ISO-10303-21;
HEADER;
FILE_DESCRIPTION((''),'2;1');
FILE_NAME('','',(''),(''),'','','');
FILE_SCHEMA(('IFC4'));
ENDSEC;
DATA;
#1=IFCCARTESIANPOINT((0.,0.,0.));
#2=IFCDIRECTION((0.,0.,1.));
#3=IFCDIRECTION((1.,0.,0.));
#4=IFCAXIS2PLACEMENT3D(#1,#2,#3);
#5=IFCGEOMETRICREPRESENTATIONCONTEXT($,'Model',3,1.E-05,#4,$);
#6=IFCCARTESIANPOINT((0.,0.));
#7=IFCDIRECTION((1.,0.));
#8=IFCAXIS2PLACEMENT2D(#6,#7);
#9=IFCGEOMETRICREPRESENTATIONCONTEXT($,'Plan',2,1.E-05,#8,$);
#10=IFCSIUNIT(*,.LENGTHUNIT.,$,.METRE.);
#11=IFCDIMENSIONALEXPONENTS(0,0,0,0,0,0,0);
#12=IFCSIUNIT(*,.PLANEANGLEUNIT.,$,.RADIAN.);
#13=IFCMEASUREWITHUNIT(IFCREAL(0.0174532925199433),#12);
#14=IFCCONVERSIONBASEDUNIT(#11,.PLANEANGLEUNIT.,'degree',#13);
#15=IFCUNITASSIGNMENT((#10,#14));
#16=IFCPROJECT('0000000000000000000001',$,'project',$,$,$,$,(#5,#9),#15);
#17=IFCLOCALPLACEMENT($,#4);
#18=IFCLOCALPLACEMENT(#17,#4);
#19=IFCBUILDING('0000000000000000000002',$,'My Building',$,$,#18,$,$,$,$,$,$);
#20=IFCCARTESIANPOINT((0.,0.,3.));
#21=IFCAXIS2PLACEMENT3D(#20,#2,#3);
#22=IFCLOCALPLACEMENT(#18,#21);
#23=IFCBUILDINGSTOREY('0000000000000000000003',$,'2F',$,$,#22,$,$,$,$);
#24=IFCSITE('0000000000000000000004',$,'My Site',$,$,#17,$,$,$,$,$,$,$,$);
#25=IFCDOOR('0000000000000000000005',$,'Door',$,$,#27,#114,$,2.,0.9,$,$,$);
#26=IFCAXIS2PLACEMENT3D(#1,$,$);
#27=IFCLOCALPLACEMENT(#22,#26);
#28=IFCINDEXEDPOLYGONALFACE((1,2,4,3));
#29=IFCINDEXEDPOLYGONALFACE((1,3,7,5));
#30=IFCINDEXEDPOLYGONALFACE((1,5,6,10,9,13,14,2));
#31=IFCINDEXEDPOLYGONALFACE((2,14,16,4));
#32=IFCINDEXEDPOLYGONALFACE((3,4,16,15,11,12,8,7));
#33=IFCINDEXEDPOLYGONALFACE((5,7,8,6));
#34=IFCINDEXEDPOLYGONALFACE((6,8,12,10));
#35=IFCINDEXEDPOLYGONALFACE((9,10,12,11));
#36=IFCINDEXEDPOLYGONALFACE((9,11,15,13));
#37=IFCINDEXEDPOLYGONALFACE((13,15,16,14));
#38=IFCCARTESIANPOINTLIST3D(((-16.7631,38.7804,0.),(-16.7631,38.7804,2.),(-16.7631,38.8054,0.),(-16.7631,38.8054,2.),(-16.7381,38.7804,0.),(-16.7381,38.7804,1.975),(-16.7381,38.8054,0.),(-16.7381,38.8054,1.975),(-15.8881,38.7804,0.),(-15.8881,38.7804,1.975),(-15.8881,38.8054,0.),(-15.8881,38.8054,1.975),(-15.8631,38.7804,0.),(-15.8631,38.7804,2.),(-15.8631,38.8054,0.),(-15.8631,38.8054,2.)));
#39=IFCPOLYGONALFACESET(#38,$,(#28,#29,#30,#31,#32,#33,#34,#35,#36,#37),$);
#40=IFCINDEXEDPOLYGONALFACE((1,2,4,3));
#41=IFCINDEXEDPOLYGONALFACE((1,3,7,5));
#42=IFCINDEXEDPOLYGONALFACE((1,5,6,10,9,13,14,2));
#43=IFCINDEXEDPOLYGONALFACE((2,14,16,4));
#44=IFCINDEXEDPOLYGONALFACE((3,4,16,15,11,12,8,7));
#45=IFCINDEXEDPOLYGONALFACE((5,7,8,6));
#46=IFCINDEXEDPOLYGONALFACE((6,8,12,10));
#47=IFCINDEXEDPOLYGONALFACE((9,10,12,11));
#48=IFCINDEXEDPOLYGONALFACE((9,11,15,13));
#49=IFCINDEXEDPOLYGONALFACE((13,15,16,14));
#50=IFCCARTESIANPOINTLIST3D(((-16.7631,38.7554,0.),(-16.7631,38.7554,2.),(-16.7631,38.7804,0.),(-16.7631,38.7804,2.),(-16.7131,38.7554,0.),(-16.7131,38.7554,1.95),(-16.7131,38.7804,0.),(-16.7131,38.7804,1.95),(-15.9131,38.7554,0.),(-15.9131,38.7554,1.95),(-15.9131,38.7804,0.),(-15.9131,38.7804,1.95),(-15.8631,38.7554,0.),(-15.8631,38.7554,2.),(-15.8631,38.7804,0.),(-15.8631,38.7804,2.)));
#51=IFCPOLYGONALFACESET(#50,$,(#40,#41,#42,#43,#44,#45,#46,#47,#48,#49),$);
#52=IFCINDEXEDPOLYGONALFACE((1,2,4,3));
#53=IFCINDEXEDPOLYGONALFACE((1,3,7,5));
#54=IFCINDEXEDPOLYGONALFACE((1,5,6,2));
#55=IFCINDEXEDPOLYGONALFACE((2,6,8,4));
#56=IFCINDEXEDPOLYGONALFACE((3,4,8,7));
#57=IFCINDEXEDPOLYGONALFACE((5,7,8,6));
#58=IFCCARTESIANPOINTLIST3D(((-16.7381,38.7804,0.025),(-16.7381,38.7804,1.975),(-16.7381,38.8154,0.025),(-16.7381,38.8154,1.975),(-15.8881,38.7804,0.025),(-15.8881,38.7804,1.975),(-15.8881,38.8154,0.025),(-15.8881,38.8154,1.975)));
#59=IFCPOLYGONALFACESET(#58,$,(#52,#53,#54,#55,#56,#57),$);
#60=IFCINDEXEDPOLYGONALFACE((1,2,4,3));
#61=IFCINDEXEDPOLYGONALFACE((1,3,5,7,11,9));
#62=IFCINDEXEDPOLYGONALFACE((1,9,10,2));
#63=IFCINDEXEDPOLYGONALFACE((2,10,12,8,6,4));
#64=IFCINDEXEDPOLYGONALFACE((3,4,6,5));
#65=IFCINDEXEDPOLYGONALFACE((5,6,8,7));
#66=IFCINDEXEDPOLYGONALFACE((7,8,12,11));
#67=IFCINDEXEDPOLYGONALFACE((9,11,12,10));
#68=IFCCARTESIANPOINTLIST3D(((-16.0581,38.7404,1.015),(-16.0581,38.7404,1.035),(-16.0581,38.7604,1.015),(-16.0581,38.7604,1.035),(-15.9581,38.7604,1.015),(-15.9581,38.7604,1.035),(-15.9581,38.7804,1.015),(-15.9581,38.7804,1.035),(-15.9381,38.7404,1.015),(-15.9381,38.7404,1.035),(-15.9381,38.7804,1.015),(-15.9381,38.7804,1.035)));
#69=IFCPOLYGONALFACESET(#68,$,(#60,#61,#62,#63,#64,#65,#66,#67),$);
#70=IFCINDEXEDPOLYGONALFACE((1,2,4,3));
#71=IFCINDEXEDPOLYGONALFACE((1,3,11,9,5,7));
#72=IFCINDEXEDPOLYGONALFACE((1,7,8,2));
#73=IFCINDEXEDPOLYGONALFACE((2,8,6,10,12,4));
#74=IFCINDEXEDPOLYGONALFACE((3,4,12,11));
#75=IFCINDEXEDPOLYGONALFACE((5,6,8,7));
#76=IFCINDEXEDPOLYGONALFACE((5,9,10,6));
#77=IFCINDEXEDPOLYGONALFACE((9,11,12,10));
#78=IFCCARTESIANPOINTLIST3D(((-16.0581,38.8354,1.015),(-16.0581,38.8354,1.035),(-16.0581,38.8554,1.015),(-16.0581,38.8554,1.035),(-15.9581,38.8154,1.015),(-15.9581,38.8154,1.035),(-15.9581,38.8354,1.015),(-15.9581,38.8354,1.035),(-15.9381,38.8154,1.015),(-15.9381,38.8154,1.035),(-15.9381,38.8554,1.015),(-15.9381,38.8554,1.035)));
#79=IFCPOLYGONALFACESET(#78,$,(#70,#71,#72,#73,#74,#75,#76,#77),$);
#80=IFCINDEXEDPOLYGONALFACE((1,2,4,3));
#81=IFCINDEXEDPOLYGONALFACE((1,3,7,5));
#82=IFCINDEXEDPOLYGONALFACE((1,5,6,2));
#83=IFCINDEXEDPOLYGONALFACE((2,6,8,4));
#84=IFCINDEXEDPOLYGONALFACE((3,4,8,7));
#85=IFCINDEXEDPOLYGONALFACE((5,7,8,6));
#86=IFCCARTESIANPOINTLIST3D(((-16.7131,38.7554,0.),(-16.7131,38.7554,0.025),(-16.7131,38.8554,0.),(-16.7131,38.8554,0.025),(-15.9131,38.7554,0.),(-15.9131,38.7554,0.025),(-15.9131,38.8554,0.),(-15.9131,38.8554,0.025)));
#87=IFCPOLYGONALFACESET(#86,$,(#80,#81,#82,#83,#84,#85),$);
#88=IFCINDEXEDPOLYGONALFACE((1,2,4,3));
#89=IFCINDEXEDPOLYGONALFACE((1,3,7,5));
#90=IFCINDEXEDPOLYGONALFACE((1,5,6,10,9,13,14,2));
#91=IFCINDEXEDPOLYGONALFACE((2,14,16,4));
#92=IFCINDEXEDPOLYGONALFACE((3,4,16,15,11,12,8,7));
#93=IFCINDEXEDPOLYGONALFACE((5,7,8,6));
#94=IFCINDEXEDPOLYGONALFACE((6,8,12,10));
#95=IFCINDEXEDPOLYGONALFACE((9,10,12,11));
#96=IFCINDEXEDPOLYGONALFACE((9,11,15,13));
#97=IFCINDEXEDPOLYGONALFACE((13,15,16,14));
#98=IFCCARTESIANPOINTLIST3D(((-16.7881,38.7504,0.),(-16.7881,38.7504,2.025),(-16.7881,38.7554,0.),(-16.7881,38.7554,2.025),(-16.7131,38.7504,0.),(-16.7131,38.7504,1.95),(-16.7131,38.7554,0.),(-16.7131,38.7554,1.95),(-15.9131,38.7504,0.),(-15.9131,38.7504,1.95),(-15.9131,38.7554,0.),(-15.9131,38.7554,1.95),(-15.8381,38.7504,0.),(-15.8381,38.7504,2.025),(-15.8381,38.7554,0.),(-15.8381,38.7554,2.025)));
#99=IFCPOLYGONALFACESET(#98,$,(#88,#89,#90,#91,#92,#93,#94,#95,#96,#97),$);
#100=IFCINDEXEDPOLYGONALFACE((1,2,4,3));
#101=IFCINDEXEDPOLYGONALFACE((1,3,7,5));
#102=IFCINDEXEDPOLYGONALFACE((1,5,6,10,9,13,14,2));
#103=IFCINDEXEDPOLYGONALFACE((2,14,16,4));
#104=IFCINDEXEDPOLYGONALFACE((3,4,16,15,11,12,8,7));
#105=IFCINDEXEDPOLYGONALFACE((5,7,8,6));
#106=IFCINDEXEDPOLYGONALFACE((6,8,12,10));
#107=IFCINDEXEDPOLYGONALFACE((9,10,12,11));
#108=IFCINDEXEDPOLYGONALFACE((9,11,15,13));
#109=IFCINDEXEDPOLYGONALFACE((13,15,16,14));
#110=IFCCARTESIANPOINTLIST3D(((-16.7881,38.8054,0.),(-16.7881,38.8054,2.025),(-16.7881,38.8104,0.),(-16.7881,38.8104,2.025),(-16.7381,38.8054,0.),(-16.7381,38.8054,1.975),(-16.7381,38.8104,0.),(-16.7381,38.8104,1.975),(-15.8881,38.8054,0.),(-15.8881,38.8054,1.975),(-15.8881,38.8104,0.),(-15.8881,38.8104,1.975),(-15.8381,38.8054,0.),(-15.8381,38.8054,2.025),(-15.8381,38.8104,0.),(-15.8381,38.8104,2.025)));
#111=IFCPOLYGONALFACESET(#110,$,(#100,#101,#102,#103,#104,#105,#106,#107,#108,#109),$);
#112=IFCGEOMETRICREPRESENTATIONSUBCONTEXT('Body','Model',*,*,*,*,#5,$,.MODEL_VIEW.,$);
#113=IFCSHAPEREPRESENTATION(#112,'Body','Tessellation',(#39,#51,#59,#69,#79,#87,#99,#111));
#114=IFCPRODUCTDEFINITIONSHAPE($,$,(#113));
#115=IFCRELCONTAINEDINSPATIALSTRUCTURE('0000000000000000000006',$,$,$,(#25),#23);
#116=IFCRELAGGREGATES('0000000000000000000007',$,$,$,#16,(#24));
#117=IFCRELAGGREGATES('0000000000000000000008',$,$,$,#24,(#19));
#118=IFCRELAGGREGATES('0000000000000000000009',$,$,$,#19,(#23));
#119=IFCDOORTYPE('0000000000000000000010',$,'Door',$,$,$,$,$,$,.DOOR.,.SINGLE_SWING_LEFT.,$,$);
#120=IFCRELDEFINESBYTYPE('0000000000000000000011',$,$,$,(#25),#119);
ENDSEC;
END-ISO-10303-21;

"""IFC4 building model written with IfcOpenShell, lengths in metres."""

from ifc_helpers import new_model, entity, si_unit, converted_unit, frame, origin_with_axes, origin_2d_with_axis, place, context, subcontext, project, spatial, line, indexed_curve, outline, extrude, shape, source, transform, mapped, type_object, type_shapes, element, save


model = new_model("IFC4")

# Units and contexts
model_context = context("Model", 3, precision=1e-05, world=origin_with_axes())
plan_context = context("Plan", 2, precision=1e-05, world=origin_2d_with_axis())
body_context_1 = subcontext(model_context, "Body", "Model", "MODEL_VIEW")
body_context_2 = subcontext(plan_context, "Body", "Plan", "PLAN_VIEW")
ifc_project = project(units=[si_unit("LENGTHUNIT", "METRE"), converted_unit("PLANEANGLEUNIT", "degree", entity("IfcReal", 0.0174532925199433), si_unit("PLANEANGLEUNIT", "RADIAN"), dimensions=[0, 0, 0, 0, 0, 0, 0])], contexts=[model_context, plan_context])

# Site, building, storey
site_placement = place(None, origin_with_axes())
site = spatial("IfcSite", under=ifc_project, at=site_placement, Name="My Site")
building_placement = place(site_placement, origin_with_axes())
building = spatial("IfcBuilding", under=site, at=building_placement, Name="My Building")
storey_placement = place(building_placement, frame((0.0, 0.0, 3.0), z_axis=(0.0, 0.0, 1.0), x_axis=(1.0, 0.0, 0.0)))
storey = spatial("IfcBuildingStorey", under=building, at=storey_placement, Name="2F")

# Shared definitions
door_type = type_object("IfcDoorType", Name="Door", OperationType="SINGLE_SWING_LEFT", PredefinedType="DOOR")
shared_shape_1 = source(origin_with_axes(), body_context_1, "Body", "SweptSolid", [
    extrude(outline(indexed_curve([(0.0, 0.0), (0.0, 2.0), (0.9, 2.0), (0.9, 0.0), (0.875, 0.0), (0.875, 1.975), (0.025, 1.975), (0.025, 0.0)], segments=[line(1, 2, 3, 4, 5, 6, 7, 8, 1)])), frame((0.0, 0.025, 0.0), z_axis=(0.0, -1.0, 0.0), x_axis=(1.0, 0.0, 0.0)), (0.0, 0.0, -1.0), 0.025),
    extrude(outline(indexed_curve([(0.0, 0.0), (0.0, 2.0), (0.9, 2.0), (0.9, 0.0), (0.85, 0.0), (0.85, 1.95), (0.05, 1.95), (0.05, 0.0)], segments=[line(1, 2, 3, 4, 5, 6, 7, 8, 1)])), frame((0.0, 0.0, 0.0), z_axis=(0.0, -1.0, 0.0), x_axis=(1.0, 0.0, 0.0)), (0.0, 0.0, -1.0), 0.025),
    extrude(outline(indexed_curve([(0.0, 0.0), (0.85, 0.0), (0.85, 0.035), (0.0, 0.035)], segments=[line(1, 2, 3, 4, 1)])), frame((0.025, 0.025, 0.025), z_axis=(0.0, 0.0, 1.0), x_axis=(1.0, 0.0, 0.0)), (0.0, 0.0, 1.0), 1.95),
    extrude(outline(indexed_curve([(0.0, 0.0), (0.0, -0.04), (-0.12, -0.04), (-0.12, -0.02), (-0.02, -0.02), (-0.02, 0.0)], segments=[line(1, 2, 3, 4, 5, 6, 1)])), frame((0.825, 0.025, 1.015), z_axis=(0.0, 0.0, 1.0), x_axis=(1.0, 0.0, 0.0)), (0.0, 0.0, 1.0), 0.02),
    extrude(outline(indexed_curve([(0.0, 0.0), (0.0, 0.04), (-0.12, 0.04), (-0.12, 0.02), (-0.02, 0.02), (-0.02, 0.0)], segments=[line(1, 2, 3, 4, 5, 6, 1)])), frame((0.825, 0.06, 1.015), z_axis=(0.0, 0.0, 1.0), x_axis=(1.0, 0.0, 0.0)), (0.0, 0.0, 1.0), 0.02),
    extrude(outline(indexed_curve([(0.0, 0.0), (0.8, 0.0), (0.8, 0.1), (0.0, 0.1)], segments=[line(1, 2, 3, 4, 1)])), frame((0.05, 0.0, 0.0), z_axis=(0.0, 0.0, 1.0), x_axis=(1.0, 0.0, 0.0)), (0.0, 0.0, 1.0), 0.025),
    extrude(outline(indexed_curve([(0.0, 0.0), (0.0, 2.025), (0.95, 2.025), (0.95, 0.0), (0.875, 0.0), (0.875, 1.95), (0.075, 1.95), (0.075, 0.0)], segments=[line(1, 2, 3, 4, 5, 6, 7, 8, 1)])), frame((-0.025, -0.005, 0.0), z_axis=(0.0, -1.0, 0.0), x_axis=(1.0, 0.0, 0.0)), (0.0, 0.0, -1.0), 0.005),
    extrude(outline(indexed_curve([(0.0, 0.0), (0.0, 2.025), (0.95, 2.025), (0.95, 0.0), (0.9, 0.0), (0.9, 1.975), (0.05, 1.975), (0.05, 0.0)], segments=[line(1, 2, 3, 4, 5, 6, 7, 8, 1)])), frame((-0.025, 0.05, 0.0), z_axis=(0.0, -1.0, 0.0), x_axis=(1.0, 0.0, 0.0)), (0.0, 0.0, -1.0), 0.005),
])
shared_shape_2 = source(origin_with_axes(), body_context_2, "Body", "Curve2D", [
    entity("IfcIndexedPolyCurve", entity("IfcCartesianPointList2D", [[0.0, 0.0], [0.0, 0.05], [0.025, 0.05], [0.025, 0.025], [0.05, 0.025], [0.05, 0.0]]), [entity("IfcLineIndex", [1, 2, 3, 4, 5, 6, 1])]),
    entity("IfcIndexedPolyCurve", entity("IfcCartesianPointList2D", [[0.9, 0.0], [0.9, 0.05], [0.875, 0.05], [0.875, 0.025], [0.85, 0.025], [0.85, 0.0]]), [entity("IfcLineIndex", [1, 2, 3, 4, 5, 6, 1])]),
    entity("IfcTrimmedCurve", entity("IfcEllipse", entity("IfcAxis2Placement2D", entity("IfcCartesianPoint", [0.06, 0.05]), entity("IfcDirection", [1.0, 0.0])), 0.815, 0.85), [entity("IfcCartesianPoint", [0.875, 0.05])], [entity("IfcCartesianPoint", [0.06, 0.9])], True, "CARTESIAN"),
    entity("IfcIndexedPolyCurve", entity("IfcCartesianPointList2D", [[0.025, 0.05], [0.06, 0.05], [0.06, 0.9], [0.025, 0.9]]), [entity("IfcLineIndex", [1, 2, 3, 4, 1])]),
])
type_shapes(door_type, [shared_shape_1, shared_shape_2])

# Door
door_1_placement = place(storey_placement, frame((-16.7631, 38.7554, 0.0), z_axis=(0.0, 0.0, 1.0), x_axis=(1.0, 0.0, 0.0)))
element("IfcDoor", 1, at=door_1_placement, inside=storey, type_object=door_type, Name="Door", OverallHeight=2.0, OverallWidth=0.9, shapes=[
    shape(body_context_1, "Body", "MappedRepresentation", [mapped(shared_shape_1, transform((0.0, 0.0, 0.0), x_axis=(1.0, 0.0, 0.0), y_axis=(0.0, 1.0, 0.0), z_axis=(0.0, 0.0, 1.0), scale=1.0))]),
    shape(body_context_2, "Body", "MappedRepresentation", [mapped(shared_shape_2, transform((0.0, 0.0, 0.0), x_axis=(1.0, 0.0, 0.0), y_axis=(0.0, 1.0, 0.0), z_axis=(0.0, 0.0, 1.0), scale=1.0))]),
])

save(model, "model.ifc")
